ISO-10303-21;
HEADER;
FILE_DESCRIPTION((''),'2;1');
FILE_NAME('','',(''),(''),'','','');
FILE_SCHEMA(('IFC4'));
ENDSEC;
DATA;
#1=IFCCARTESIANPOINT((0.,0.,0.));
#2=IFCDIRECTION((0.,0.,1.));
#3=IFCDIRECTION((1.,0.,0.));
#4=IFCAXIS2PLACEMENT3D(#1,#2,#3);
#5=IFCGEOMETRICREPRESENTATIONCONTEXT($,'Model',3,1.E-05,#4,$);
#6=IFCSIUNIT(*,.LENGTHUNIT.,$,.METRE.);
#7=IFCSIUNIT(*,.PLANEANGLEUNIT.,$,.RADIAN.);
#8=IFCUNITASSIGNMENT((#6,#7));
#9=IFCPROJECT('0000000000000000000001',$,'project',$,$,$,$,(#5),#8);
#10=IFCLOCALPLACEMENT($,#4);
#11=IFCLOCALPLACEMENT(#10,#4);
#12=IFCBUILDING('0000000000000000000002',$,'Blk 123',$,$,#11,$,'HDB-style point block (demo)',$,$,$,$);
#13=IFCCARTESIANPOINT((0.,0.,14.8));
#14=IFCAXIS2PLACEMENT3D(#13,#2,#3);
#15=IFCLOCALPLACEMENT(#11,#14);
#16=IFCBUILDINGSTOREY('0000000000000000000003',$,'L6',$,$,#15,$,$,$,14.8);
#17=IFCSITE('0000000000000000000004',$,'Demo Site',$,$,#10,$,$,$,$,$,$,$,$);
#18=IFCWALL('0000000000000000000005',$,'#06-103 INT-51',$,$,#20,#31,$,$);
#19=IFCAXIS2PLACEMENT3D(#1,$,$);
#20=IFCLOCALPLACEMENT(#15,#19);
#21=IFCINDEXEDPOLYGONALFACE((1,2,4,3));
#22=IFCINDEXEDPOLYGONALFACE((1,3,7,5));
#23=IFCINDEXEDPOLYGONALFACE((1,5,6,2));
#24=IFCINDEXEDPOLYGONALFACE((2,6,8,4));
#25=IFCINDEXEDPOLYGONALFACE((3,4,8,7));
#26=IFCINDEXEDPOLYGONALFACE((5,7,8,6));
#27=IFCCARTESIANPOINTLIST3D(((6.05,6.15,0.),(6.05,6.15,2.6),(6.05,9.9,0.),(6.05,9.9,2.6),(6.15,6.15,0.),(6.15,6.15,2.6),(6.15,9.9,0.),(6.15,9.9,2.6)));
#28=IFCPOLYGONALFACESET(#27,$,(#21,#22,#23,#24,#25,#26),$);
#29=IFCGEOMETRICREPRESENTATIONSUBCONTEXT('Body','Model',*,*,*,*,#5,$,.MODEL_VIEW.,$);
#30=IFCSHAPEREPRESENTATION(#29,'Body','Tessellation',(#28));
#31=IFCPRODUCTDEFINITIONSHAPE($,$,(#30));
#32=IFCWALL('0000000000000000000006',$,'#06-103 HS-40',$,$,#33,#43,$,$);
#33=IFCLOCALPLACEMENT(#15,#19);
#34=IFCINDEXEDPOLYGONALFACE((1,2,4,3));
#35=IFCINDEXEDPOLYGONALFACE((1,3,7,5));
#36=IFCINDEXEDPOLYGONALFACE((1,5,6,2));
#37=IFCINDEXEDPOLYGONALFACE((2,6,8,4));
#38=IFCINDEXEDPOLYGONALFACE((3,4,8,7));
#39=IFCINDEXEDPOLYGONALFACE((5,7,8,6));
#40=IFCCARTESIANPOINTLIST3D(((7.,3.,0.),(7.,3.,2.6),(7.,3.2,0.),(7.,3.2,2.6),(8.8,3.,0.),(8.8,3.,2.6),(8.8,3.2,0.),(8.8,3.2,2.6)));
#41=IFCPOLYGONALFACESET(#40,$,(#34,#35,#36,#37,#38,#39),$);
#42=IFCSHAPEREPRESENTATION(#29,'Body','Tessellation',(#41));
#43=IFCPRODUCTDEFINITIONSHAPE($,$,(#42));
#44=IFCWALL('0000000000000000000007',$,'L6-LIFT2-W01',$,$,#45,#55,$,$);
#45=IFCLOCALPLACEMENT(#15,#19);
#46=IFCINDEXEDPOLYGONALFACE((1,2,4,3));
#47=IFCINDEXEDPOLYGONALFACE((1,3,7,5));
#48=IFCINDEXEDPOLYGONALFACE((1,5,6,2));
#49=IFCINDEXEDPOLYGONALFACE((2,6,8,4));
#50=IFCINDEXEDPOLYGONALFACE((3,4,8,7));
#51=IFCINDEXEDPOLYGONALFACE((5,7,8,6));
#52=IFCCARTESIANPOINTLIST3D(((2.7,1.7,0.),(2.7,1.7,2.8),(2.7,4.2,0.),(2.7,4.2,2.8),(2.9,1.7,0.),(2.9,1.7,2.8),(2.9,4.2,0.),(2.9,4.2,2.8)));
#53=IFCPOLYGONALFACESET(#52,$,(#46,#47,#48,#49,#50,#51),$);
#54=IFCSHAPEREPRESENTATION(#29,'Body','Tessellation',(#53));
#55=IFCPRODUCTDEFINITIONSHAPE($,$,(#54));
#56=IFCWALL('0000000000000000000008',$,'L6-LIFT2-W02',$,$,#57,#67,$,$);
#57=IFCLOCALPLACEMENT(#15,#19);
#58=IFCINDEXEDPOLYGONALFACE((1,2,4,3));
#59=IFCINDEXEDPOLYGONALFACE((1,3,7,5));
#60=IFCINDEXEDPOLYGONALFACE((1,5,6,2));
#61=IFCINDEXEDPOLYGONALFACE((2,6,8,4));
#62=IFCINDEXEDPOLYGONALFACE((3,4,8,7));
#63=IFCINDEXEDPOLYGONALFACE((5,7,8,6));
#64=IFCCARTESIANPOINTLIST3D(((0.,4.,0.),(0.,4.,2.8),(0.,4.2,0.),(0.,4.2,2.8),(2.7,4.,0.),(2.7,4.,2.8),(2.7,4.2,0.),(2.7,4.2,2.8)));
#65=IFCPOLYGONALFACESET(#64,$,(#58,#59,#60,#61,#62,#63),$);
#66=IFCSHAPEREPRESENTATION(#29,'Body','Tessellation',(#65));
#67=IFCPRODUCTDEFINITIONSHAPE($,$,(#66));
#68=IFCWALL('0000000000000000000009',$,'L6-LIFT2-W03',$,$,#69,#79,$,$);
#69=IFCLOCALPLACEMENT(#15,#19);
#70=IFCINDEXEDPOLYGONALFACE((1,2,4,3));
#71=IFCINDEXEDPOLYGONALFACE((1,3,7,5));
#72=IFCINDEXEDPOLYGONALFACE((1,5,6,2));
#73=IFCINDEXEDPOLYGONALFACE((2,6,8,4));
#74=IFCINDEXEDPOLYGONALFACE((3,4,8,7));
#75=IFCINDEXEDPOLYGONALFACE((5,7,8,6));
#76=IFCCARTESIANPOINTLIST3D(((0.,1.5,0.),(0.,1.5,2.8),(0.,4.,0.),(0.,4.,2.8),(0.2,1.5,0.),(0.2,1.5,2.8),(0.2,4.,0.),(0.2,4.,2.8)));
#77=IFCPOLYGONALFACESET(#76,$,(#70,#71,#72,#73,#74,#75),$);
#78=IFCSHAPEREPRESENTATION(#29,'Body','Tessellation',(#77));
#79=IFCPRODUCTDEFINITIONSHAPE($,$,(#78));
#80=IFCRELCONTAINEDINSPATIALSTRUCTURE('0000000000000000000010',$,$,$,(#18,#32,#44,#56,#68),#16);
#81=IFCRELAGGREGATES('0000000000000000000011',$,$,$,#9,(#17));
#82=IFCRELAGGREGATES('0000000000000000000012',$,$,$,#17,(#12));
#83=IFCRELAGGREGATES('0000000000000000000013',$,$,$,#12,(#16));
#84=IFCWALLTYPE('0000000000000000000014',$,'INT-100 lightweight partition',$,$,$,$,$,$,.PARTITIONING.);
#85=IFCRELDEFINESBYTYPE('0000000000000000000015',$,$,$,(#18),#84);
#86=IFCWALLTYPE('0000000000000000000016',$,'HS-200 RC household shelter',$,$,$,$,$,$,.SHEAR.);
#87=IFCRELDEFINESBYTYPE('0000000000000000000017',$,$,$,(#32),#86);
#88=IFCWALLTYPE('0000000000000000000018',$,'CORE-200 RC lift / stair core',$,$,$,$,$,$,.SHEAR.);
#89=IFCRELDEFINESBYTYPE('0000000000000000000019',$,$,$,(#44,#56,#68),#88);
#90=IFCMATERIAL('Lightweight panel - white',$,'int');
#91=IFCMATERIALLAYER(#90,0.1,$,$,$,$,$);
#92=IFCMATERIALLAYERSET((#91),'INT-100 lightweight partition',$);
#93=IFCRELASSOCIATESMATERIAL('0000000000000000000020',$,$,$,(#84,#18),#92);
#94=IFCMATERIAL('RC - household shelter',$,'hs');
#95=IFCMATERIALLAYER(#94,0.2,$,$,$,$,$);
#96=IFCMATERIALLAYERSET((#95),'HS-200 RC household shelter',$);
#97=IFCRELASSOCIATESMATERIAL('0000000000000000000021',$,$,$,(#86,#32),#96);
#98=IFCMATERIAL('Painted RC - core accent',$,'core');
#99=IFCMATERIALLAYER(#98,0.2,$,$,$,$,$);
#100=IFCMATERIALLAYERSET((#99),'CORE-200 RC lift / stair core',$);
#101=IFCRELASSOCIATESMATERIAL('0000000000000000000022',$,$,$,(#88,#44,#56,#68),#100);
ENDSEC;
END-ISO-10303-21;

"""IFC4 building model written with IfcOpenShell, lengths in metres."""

from ifc_helpers import new_model, si_unit, frame, origin_with_axes, place, context, subcontext, project, spatial, indexed_curve, outline, extrude, material, layer, layer_set, layer_usage, type_object, element, save


model = new_model("IFC4")

# Units and contexts
model_context = context("Model", 3, precision=1e-05, world=origin_with_axes())
body_context = subcontext(model_context, "Body", "Model", "MODEL_VIEW")
ifc_project = project(units=[si_unit("LENGTHUNIT", "METRE"), si_unit("PLANEANGLEUNIT", "RADIAN")], contexts=[model_context])

# Site, building, storey
site_placement = place(None, origin_with_axes())
site = spatial("IfcSite", under=ifc_project, at=site_placement, Name="Demo Site")
building_placement = place(site_placement, origin_with_axes())
building = spatial("IfcBuilding", under=site, at=building_placement, Name="Blk 123", LongName="HDB-style point block (demo)")
storey_placement = place(building_placement, frame((0.0, 0.0, 14.8), z_axis=(0.0, 0.0, 1.0), x_axis=(1.0, 0.0, 0.0)))
storey = spatial("IfcBuildingStorey", under=building, at=storey_placement, Name="L6", Elevation=14.8)

# Shared definitions
ifc_material_1 = material(Name="Lightweight panel - white", Category="int")
ifc_layer_1 = layer(ifc_material_1, 0.1)
ifc_layer_set_1 = layer_set([ifc_layer_1], Name="INT-100 lightweight partition")
ifc_layer_usage_1 = layer_usage(ifc_layer_set_1, "AXIS2", "POSITIVE", -0.05)
wall_type_1 = type_object("IfcWallType", Name="INT-100 lightweight partition", PredefinedType="PARTITIONING", material=ifc_layer_set_1)

# Walls
wall_1_placement = place(storey_placement, frame((6.1, 6.15, 0.0), z_axis=(0.0, 0.0, 1.0), x_axis=(0.0, 1.0, 0.0)))
element("IfcWall", 1, at=wall_1_placement, inside=storey, type_object=wall_type_1, material=ifc_layer_usage_1, Name="#06-103 INT-51", context=body_context, shape_type="SweptSolid", body=[
    extrude(outline(indexed_curve([(0.0, 0.0), (0.0, 0.1), (3.75, 0.1), (3.75, 0.0), (0.0, 0.0)], self_intersect=False)), frame((0.0, -0.05, 0.0), z_axis=(0.0, 0.0, 1.0), x_axis=(1.0, 0.0, 0.0)), (0.0, 0.0, 1.0), 2.6),
])
ifc_material_2 = material(Name="RC - household shelter", Category="hs")
ifc_layer_2 = layer(ifc_material_2, 0.2)
ifc_layer_set_2 = layer_set([ifc_layer_2], Name="HS-200 RC household shelter")
ifc_layer_usage_2 = layer_usage(ifc_layer_set_2, "AXIS2", "POSITIVE", -0.1)
wall_type_2 = type_object("IfcWallType", Name="HS-200 RC household shelter", PredefinedType="SHEAR", material=ifc_layer_set_2)
wall_2_placement = place(storey_placement, frame((7.0, 3.1, 0.0), z_axis=(0.0, 0.0, 1.0), x_axis=(1.0, 0.0, 0.0)))
element("IfcWall", 2, at=wall_2_placement, inside=storey, type_object=wall_type_2, material=ifc_layer_usage_2, Name="#06-103 HS-40", context=body_context, shape_type="SweptSolid", body=[
    extrude(outline(indexed_curve([(0.0, 0.0), (0.0, 0.2), (1.8, 0.2), (1.8, 0.0), (0.0, 0.0)], self_intersect=False)), frame((0.0, -0.1, 0.0), z_axis=(0.0, 0.0, 1.0), x_axis=(1.0, 0.0, 0.0)), (0.0, 0.0, 1.0), 2.6),
])
ifc_material_3 = material(Name="Painted RC - core accent", Category="core")
ifc_layer_3 = layer(ifc_material_3, 0.2)
ifc_layer_set_3 = layer_set([ifc_layer_3], Name="CORE-200 RC lift / stair core")
ifc_layer_usage_3 = layer_usage(ifc_layer_set_3, "AXIS2", "POSITIVE", 0.0)
wall_type_3 = type_object("IfcWallType", Name="CORE-200 RC lift / stair core", PredefinedType="SHEAR", material=ifc_layer_set_3)
wall_3_placement = place(storey_placement, frame((2.9, 1.7, 0.0), z_axis=(0.0, 0.0, 1.0), x_axis=(0.0, 1.0, 0.0)))
element("IfcWall", 3, at=wall_3_placement, inside=storey, type_object=wall_type_3, material=ifc_layer_usage_3, Name="L6-LIFT2-W01", context=body_context, shape_type="SweptSolid", body=[
    extrude(outline(indexed_curve([(0.0, 0.0), (0.0, 0.2), (2.5, 0.2), (2.5, 0.0), (0.0, 0.0)], self_intersect=False)), origin_with_axes(), (0.0, 0.0, 1.0), 2.8),
])
wall_4_placement = place(storey_placement, frame((2.7, 4.2, 0.0), z_axis=(0.0, 0.0, 1.0), x_axis=(-1.0, 0.0, 0.0)))
element("IfcWall", 4, at=wall_4_placement, inside=storey, type_object=wall_type_3, material=ifc_layer_usage_3, Name="L6-LIFT2-W02", context=body_context, shape_type="SweptSolid", body=[
    extrude(outline(indexed_curve([(0.0, 0.0), (0.0, 0.2), (2.7, 0.2), (2.7, 0.0), (0.0, 0.0)], self_intersect=False)), origin_with_axes(), (0.0, 0.0, 1.0), 2.8),
])
wall_5_placement = place(storey_placement, frame((0.0, 4.0, 0.0), z_axis=(0.0, 0.0, 1.0), x_axis=(0.0, -1.0, 0.0)))
element("IfcWall", 5, at=wall_5_placement, inside=storey, type_object=wall_type_3, material=ifc_layer_usage_3, Name="L6-LIFT2-W03", context=body_context, shape_type="SweptSolid", body=[
    extrude(outline(indexed_curve([(0.0, 0.0), (0.0, 0.2), (2.5, 0.2), (2.5, 0.0), (0.0, 0.0)], self_intersect=False)), origin_with_axes(), (0.0, 0.0, 1.0), 2.8),
])

save(model, "model.ifc")
